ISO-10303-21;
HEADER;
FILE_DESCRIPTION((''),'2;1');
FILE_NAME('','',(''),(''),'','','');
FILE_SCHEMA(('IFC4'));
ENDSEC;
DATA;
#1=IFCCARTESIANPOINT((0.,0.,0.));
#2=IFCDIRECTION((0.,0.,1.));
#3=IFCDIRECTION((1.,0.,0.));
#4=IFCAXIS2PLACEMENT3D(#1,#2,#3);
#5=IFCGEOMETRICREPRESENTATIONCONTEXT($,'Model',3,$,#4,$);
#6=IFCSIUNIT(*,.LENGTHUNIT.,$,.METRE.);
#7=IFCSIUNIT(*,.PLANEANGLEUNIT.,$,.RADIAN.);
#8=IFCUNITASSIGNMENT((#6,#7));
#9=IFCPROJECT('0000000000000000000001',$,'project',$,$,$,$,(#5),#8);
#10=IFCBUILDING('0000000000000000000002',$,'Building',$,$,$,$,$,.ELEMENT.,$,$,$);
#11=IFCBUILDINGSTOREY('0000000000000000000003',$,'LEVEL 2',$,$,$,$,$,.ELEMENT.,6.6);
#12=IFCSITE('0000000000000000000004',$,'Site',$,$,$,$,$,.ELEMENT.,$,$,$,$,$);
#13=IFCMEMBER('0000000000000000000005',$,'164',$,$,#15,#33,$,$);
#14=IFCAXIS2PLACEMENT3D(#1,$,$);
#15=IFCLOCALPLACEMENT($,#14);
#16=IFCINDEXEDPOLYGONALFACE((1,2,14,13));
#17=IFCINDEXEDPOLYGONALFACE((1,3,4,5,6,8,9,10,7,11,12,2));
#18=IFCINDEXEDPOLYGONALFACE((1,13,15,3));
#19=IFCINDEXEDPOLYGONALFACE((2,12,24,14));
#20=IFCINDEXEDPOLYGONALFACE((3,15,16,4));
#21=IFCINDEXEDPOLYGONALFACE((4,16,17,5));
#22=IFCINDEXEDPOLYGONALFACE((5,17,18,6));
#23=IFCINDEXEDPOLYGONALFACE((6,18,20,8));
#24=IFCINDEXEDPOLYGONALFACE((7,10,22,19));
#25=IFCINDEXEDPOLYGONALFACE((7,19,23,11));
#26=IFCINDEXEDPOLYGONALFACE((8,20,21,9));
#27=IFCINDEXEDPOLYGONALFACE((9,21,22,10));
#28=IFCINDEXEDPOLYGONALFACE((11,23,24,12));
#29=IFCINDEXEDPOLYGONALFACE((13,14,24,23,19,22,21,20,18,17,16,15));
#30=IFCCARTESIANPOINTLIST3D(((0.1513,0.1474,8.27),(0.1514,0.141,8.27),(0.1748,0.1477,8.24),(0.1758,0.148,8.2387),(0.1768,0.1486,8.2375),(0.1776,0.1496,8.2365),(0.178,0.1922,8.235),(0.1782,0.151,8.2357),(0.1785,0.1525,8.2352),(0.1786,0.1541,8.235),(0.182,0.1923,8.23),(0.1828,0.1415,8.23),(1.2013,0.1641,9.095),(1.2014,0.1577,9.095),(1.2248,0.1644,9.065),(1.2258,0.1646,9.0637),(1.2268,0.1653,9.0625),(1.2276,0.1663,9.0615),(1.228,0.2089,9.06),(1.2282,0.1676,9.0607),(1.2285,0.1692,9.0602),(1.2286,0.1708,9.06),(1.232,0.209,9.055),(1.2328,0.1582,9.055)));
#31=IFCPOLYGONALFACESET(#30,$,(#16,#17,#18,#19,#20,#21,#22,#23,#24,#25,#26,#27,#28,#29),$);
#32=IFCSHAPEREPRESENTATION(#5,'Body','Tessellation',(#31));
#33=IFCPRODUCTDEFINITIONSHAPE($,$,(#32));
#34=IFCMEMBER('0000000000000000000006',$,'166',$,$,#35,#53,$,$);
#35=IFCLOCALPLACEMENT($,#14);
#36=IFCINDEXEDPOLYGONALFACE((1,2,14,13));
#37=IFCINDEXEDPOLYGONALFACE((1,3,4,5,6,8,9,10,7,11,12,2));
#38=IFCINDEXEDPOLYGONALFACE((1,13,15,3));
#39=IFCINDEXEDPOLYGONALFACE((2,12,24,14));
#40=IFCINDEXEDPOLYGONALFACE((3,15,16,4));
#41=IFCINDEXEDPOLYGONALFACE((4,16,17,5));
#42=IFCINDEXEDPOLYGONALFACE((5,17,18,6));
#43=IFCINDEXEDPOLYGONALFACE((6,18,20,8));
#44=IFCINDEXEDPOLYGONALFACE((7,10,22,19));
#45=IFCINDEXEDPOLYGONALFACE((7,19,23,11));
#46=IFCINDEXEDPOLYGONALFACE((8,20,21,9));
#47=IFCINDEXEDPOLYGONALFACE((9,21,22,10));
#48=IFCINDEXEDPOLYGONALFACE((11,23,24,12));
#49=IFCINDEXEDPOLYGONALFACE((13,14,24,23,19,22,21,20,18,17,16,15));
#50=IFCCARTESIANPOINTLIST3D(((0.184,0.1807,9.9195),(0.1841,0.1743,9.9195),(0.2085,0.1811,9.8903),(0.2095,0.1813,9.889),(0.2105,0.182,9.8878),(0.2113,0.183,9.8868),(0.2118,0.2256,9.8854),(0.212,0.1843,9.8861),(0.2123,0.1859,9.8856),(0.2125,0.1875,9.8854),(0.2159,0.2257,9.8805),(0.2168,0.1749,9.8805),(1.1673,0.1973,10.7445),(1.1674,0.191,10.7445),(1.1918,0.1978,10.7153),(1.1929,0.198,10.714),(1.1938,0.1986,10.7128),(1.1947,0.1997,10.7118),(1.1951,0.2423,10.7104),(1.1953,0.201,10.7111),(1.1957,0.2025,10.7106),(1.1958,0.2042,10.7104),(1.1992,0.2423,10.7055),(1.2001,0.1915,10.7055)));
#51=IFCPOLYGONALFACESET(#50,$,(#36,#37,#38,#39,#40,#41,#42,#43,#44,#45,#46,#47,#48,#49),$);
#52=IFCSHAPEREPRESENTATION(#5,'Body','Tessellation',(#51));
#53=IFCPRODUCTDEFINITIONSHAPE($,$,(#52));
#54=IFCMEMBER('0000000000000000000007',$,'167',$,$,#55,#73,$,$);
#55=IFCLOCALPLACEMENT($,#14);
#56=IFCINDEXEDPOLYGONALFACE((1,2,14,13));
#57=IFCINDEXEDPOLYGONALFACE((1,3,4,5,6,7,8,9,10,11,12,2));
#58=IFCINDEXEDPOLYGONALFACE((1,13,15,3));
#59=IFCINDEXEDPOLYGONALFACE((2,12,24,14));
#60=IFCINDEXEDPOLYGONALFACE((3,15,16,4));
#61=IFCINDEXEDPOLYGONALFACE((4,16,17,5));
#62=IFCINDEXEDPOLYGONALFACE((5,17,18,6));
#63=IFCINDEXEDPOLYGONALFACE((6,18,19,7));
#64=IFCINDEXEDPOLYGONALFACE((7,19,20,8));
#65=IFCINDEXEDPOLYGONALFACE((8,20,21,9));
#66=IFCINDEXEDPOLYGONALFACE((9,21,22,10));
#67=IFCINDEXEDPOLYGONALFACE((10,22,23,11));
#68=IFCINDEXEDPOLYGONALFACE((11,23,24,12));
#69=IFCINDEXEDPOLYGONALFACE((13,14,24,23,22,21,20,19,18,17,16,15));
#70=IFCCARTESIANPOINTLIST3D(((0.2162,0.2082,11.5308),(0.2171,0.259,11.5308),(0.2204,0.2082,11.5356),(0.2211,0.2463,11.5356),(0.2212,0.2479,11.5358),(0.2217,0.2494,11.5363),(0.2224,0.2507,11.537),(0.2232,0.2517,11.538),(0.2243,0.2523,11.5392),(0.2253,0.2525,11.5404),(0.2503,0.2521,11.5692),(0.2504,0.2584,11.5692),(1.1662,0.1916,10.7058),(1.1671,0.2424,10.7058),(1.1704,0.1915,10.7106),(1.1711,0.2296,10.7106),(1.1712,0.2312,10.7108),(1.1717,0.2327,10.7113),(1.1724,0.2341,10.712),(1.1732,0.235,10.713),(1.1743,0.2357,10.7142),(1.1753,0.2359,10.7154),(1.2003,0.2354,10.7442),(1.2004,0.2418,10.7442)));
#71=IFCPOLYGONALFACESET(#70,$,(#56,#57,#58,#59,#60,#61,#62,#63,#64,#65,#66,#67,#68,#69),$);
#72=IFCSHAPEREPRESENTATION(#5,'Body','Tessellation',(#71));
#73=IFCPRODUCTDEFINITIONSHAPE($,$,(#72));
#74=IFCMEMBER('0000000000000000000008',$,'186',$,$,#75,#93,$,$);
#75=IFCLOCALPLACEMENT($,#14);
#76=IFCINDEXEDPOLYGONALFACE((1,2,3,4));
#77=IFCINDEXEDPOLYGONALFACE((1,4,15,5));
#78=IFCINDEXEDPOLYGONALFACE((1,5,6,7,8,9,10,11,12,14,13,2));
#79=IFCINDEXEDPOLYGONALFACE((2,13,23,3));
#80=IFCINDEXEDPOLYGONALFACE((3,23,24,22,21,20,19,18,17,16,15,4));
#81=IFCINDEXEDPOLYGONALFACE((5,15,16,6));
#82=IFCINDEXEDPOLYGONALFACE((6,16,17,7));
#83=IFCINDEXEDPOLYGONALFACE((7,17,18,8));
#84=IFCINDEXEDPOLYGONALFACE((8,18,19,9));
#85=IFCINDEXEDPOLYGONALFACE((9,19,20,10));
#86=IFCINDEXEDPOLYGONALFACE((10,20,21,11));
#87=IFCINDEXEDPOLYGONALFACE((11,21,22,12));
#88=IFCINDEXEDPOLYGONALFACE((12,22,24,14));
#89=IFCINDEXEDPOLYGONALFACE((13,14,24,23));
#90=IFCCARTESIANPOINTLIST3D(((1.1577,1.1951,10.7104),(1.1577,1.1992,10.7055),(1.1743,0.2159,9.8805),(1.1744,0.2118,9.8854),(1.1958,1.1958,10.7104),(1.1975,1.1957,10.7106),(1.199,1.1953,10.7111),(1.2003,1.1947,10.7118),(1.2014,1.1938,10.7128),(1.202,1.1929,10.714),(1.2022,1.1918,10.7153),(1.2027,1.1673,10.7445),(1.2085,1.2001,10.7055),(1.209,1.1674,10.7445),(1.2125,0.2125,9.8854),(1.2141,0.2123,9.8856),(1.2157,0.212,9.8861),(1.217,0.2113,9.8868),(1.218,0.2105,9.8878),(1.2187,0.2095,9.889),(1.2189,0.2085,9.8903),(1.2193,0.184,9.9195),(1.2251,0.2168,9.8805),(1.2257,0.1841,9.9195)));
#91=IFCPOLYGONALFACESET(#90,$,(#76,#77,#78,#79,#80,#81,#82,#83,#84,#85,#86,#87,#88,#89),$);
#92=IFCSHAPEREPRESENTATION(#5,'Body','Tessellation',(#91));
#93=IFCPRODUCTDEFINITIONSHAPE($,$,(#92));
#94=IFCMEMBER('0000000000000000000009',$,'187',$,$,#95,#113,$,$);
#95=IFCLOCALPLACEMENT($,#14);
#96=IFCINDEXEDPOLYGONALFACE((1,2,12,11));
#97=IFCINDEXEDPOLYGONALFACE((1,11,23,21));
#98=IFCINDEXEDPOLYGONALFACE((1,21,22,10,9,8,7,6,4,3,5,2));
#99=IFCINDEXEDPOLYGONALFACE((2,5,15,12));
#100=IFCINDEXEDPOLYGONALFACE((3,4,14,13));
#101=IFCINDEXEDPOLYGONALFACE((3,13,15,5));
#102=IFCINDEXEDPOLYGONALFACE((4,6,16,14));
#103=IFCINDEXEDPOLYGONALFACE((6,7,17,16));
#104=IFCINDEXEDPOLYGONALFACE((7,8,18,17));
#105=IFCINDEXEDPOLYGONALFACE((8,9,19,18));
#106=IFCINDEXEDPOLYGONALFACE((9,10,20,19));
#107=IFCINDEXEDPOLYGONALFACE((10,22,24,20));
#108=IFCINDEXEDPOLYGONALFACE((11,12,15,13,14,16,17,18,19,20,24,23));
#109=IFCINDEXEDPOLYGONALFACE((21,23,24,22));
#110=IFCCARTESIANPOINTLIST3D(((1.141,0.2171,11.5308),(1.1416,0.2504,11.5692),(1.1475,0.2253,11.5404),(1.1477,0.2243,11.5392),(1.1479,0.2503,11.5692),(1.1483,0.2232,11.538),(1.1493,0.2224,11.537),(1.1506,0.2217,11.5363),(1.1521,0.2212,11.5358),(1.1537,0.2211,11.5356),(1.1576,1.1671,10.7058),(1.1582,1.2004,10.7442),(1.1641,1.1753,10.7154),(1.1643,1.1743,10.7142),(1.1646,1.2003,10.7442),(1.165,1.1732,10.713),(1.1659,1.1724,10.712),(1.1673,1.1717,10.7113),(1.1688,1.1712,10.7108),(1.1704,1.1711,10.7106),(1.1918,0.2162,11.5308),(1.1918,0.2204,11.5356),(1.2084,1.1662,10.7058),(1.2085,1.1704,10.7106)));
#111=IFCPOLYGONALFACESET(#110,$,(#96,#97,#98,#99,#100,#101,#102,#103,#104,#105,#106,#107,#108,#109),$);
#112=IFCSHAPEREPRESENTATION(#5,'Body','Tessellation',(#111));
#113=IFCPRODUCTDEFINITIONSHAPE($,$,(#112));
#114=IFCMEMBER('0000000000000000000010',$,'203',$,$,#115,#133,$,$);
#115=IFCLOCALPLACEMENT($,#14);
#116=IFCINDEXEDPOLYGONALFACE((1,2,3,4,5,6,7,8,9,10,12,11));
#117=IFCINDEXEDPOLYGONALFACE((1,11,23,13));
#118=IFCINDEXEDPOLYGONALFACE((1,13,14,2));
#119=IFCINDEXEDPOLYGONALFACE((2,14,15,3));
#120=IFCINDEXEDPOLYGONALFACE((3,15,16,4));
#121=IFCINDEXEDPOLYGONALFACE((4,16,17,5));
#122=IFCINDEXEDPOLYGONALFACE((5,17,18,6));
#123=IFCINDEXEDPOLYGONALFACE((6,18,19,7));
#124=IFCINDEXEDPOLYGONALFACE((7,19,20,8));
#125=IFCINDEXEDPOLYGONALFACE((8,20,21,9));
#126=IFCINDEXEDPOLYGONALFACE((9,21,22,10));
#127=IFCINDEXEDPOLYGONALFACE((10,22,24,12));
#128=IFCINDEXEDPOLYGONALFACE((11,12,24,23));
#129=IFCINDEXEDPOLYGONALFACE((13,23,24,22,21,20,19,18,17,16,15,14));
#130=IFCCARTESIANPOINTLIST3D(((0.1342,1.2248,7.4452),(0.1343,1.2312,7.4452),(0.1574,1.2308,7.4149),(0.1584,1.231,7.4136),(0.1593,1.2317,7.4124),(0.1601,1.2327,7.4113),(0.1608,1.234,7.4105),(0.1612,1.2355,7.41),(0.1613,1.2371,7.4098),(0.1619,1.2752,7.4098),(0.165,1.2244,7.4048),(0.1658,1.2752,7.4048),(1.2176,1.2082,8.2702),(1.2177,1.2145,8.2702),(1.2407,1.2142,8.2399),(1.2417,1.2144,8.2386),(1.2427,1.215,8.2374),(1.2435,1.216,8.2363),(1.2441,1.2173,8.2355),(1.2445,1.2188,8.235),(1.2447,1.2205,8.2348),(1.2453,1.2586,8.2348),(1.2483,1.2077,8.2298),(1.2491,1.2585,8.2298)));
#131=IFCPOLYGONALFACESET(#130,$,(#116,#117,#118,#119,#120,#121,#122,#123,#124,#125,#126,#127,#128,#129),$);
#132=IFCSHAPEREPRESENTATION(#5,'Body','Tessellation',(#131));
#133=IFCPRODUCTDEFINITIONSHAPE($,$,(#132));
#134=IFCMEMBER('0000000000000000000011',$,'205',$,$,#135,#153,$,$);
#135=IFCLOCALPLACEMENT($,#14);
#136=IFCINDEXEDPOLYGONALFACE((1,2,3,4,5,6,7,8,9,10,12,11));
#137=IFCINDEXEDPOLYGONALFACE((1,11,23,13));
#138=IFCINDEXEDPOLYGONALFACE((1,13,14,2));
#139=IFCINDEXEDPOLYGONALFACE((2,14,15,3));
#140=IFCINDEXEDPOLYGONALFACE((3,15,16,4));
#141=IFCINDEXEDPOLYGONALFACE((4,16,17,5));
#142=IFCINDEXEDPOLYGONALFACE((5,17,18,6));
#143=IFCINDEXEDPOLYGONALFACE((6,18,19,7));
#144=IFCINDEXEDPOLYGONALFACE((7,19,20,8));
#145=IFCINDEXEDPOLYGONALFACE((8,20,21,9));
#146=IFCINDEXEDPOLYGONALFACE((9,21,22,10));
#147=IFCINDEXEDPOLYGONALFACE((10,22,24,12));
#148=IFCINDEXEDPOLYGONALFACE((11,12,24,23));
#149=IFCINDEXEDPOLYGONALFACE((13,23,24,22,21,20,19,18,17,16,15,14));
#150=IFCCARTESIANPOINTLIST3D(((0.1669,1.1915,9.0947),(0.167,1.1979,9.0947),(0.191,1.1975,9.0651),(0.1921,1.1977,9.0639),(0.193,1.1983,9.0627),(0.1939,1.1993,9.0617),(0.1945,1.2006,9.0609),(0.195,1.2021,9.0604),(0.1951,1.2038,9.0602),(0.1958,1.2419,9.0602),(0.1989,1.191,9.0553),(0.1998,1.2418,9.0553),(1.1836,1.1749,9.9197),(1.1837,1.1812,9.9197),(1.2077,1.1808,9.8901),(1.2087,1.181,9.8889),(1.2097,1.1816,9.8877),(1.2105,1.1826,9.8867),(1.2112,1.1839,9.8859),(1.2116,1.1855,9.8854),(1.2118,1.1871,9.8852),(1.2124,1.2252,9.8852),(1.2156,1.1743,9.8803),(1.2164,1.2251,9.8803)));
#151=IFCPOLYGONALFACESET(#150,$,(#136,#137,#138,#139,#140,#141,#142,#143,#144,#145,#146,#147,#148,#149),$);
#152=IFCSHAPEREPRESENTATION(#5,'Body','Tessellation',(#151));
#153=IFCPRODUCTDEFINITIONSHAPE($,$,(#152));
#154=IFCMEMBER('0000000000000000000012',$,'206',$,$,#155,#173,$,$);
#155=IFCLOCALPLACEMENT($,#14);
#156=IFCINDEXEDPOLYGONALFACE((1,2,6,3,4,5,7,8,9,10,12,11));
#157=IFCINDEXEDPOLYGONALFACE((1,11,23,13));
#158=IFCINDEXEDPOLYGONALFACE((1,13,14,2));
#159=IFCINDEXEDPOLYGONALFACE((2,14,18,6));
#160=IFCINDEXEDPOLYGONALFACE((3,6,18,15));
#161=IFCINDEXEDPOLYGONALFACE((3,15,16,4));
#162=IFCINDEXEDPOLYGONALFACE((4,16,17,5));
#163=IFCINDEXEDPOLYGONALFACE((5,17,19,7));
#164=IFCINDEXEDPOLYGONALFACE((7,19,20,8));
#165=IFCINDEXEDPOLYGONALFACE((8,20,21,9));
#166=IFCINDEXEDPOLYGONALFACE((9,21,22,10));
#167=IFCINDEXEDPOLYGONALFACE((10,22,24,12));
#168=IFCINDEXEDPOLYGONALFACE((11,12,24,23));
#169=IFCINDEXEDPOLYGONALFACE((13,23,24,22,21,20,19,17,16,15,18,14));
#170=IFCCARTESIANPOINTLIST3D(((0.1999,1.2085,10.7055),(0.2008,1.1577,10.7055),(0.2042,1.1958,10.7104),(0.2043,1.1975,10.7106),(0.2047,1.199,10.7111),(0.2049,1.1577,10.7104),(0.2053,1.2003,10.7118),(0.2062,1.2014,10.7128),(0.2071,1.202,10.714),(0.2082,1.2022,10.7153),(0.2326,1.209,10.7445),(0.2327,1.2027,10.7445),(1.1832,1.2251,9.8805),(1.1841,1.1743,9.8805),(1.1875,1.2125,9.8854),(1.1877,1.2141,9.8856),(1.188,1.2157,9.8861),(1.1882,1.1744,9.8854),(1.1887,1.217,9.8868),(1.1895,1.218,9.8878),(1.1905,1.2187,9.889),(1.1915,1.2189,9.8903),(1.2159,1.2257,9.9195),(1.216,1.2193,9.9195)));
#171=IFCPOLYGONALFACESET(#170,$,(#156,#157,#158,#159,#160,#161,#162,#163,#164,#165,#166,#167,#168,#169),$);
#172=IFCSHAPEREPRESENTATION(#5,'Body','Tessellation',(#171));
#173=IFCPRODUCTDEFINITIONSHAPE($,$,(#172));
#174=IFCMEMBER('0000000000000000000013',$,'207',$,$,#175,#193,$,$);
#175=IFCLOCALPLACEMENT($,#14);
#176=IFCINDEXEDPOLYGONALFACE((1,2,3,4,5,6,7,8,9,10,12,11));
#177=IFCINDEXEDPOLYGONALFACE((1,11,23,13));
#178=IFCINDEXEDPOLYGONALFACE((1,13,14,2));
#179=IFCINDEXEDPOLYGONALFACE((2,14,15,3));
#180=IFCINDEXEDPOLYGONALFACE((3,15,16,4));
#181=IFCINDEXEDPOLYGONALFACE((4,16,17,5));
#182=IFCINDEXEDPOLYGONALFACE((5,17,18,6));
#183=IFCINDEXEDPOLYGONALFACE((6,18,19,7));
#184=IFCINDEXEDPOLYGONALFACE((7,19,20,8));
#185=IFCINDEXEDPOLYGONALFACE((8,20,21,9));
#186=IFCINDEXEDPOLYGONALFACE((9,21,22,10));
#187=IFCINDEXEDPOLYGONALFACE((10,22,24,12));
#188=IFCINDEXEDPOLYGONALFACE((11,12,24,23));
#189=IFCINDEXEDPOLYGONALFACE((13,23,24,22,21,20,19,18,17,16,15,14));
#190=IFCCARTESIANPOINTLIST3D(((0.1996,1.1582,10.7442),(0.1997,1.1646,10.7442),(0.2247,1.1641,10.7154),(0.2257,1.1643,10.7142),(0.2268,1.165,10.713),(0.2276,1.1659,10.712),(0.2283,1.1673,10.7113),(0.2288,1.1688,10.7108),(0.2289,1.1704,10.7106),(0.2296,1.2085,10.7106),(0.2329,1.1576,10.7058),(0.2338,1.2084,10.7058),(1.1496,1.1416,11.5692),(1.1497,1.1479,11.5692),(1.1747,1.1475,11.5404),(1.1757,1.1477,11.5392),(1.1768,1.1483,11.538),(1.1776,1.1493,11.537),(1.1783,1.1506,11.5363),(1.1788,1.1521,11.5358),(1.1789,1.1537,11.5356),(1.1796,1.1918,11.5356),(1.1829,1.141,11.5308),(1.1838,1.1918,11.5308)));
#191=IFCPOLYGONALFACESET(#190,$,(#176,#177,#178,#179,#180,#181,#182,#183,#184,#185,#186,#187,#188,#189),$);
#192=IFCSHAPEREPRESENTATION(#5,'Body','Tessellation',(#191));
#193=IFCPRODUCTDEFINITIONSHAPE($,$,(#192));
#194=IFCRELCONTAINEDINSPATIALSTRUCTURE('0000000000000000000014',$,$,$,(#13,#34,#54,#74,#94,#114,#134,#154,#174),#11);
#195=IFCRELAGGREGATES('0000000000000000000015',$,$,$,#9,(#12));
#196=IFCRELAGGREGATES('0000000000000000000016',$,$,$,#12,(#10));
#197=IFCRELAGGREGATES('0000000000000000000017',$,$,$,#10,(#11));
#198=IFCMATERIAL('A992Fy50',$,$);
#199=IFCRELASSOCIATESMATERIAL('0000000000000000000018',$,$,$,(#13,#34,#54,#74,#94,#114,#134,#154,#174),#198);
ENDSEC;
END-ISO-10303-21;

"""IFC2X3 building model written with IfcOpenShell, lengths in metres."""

from ifc_helpers import new_model, si_unit, frame, origin_with_axes, origin_2d_with_axis, place, context, project, spatial, l_section, extrude, material, element, save


model = new_model("IFC2X3")

# Units and contexts
model_context = context("Model", 3, world=origin_with_axes())
ifc_project = project(units=[si_unit("LENGTHUNIT", "METRE"), si_unit("PLANEANGLEUNIT", "RADIAN")], contexts=[model_context])

# Site, building, storey
site = spatial("IfcSite", under=ifc_project, Name="Site", CompositionType="ELEMENT")
building = spatial("IfcBuilding", under=site, Name="Building", CompositionType="ELEMENT")
storey = spatial("IfcBuildingStorey", under=building, Name="LEVEL 2", CompositionType="ELEMENT", Elevation=6.6)

# Shared definitions
ifc_material = material(Name="A992Fy50")

# Members
member_1_placement = place(None, frame((0.1667, 0.1667, 8.25), z_axis=(0.786257, 0.01248, 0.617773), x_axis=(-0.014924, 0.999889, 0.0)))
element("IfcMember", 1, at=member_1_placement, inside=storey, material=ifc_material, Name="164", context=model_context, shape_type="SweptSolid", body=[
    extrude(l_section(Depth=0.0508, Width=0.0508, Thickness=0.0063, FilletRadius=0.0063, at=origin_2d_with_axis()), origin_with_axes(), (0.0, 0.0, 1.0), 1.3354),
])
member_2_placement = place(None, frame((0.2, 0.2, 9.9), z_axis=(0.766024, 0.012983, 0.642681), x_axis=(-0.016947, 0.999856, 0.0)))
element("IfcMember", 2, at=member_2_placement, inside=storey, material=ifc_material, Name="166", context=model_context, shape_type="SweptSolid", body=[
    extrude(l_section(Depth=0.0508, Width=0.0508, Thickness=0.0063, FilletRadius=0.0063, at=origin_2d_with_axis()), origin_with_axes(), (0.0, 0.0, 1.0), 1.2837),
])
member_3_placement = place(None, frame((1.1833, 0.2167, 10.725), z_axis=(-0.754967, 0.013245, 0.655629), x_axis=(-0.017541, -0.999846, 0.0)))
element("IfcMember", 3, at=member_3_placement, inside=storey, material=ifc_material, Name="167", context=model_context, shape_type="SweptSolid", body=[
    extrude(l_section(Depth=0.0508, Width=0.0508, Thickness=0.0063, FilletRadius=0.0063, at=origin_2d_with_axis()), origin_with_axes(), (0.0, 0.0, 1.0), 1.2583),
])
member_4_placement = place(None, frame((1.2, 0.2, 9.9), z_axis=(-0.012983, 0.766024, 0.642681), x_axis=(-0.999856, -0.016947, 0.0)))
element("IfcMember", 4, at=member_4_placement, inside=storey, material=ifc_material, Name="186", context=model_context, shape_type="SweptSolid", body=[
    extrude(l_section(Depth=0.0508, Width=0.0508, Thickness=0.0063, FilletRadius=0.0063, at=origin_2d_with_axis()), origin_with_axes(), (0.0, 0.0, 1.0), 1.2837),
])
member_5_placement = place(None, frame((1.1833, 1.1833, 10.725), z_axis=(-0.013245, -0.754967, 0.655629), x_axis=(0.999846, -0.017541, 0.0)))
element("IfcMember", 5, at=member_5_placement, inside=storey, material=ifc_material, Name="187", context=model_context, shape_type="SweptSolid", body=[
    extrude(l_section(Depth=0.0508, Width=0.0508, Thickness=0.0063, FilletRadius=0.0063, at=origin_2d_with_axis()), origin_with_axes(), (0.0, 0.0, 1.0), 1.2583),
])
member_6_placement = place(None, frame((0.15, 1.25, 7.425), z_axis=(0.795513, -0.012239, 0.605813), x_axis=(0.015383, 0.999882, 0.0)))
element("IfcMember", 6, at=member_6_placement, inside=storey, material=ifc_material, Name="203", context=model_context, shape_type="SweptSolid", body=[
    extrude(l_section(Depth=0.0508, Width=0.0508, Thickness=0.0063, FilletRadius=0.0063, at=origin_2d_with_axis()), origin_with_axes(), (0.0, 0.0, 1.0), 1.3618),
])
member_7_placement = place(None, frame((0.1833, 1.2167, 9.075), z_axis=(0.77644, -0.012729, 0.630062), x_axis=(0.016391, 0.999866, 0.0)))
element("IfcMember", 7, at=member_7_placement, inside=storey, material=ifc_material, Name="205", context=model_context, shape_type="SweptSolid", body=[
    extrude(l_section(Depth=0.0508, Width=0.0508, Thickness=0.0063, FilletRadius=0.0063, at=origin_2d_with_axis()), origin_with_axes(), (0.0, 0.0, 1.0), 1.3094),
])
member_8_placement = place(None, frame((1.2, 1.2, 9.9), z_axis=(-0.766024, -0.012983, 0.642681), x_axis=(0.016947, -0.999856, 0.0)))
element("IfcMember", 8, at=member_8_placement, inside=storey, material=ifc_material, Name="206", context=model_context, shape_type="SweptSolid", body=[
    extrude(l_section(Depth=0.0508, Width=0.0508, Thickness=0.0063, FilletRadius=0.0063, at=origin_2d_with_axis()), origin_with_axes(), (0.0, 0.0, 1.0), 1.2837),
])
member_9_placement = place(None, frame((0.2167, 1.1833, 10.725), z_axis=(0.754967, -0.013245, 0.655629), x_axis=(0.017541, 0.999846, 0.0)))
element("IfcMember", 9, at=member_9_placement, inside=storey, material=ifc_material, Name="207", context=model_context, shape_type="SweptSolid", body=[
    extrude(l_section(Depth=0.0508, Width=0.0508, Thickness=0.0063, FilletRadius=0.0063, at=origin_2d_with_axis()), origin_with_axes(), (0.0, 0.0, 1.0), 1.2583),
])

save(model, "model.ifc")
